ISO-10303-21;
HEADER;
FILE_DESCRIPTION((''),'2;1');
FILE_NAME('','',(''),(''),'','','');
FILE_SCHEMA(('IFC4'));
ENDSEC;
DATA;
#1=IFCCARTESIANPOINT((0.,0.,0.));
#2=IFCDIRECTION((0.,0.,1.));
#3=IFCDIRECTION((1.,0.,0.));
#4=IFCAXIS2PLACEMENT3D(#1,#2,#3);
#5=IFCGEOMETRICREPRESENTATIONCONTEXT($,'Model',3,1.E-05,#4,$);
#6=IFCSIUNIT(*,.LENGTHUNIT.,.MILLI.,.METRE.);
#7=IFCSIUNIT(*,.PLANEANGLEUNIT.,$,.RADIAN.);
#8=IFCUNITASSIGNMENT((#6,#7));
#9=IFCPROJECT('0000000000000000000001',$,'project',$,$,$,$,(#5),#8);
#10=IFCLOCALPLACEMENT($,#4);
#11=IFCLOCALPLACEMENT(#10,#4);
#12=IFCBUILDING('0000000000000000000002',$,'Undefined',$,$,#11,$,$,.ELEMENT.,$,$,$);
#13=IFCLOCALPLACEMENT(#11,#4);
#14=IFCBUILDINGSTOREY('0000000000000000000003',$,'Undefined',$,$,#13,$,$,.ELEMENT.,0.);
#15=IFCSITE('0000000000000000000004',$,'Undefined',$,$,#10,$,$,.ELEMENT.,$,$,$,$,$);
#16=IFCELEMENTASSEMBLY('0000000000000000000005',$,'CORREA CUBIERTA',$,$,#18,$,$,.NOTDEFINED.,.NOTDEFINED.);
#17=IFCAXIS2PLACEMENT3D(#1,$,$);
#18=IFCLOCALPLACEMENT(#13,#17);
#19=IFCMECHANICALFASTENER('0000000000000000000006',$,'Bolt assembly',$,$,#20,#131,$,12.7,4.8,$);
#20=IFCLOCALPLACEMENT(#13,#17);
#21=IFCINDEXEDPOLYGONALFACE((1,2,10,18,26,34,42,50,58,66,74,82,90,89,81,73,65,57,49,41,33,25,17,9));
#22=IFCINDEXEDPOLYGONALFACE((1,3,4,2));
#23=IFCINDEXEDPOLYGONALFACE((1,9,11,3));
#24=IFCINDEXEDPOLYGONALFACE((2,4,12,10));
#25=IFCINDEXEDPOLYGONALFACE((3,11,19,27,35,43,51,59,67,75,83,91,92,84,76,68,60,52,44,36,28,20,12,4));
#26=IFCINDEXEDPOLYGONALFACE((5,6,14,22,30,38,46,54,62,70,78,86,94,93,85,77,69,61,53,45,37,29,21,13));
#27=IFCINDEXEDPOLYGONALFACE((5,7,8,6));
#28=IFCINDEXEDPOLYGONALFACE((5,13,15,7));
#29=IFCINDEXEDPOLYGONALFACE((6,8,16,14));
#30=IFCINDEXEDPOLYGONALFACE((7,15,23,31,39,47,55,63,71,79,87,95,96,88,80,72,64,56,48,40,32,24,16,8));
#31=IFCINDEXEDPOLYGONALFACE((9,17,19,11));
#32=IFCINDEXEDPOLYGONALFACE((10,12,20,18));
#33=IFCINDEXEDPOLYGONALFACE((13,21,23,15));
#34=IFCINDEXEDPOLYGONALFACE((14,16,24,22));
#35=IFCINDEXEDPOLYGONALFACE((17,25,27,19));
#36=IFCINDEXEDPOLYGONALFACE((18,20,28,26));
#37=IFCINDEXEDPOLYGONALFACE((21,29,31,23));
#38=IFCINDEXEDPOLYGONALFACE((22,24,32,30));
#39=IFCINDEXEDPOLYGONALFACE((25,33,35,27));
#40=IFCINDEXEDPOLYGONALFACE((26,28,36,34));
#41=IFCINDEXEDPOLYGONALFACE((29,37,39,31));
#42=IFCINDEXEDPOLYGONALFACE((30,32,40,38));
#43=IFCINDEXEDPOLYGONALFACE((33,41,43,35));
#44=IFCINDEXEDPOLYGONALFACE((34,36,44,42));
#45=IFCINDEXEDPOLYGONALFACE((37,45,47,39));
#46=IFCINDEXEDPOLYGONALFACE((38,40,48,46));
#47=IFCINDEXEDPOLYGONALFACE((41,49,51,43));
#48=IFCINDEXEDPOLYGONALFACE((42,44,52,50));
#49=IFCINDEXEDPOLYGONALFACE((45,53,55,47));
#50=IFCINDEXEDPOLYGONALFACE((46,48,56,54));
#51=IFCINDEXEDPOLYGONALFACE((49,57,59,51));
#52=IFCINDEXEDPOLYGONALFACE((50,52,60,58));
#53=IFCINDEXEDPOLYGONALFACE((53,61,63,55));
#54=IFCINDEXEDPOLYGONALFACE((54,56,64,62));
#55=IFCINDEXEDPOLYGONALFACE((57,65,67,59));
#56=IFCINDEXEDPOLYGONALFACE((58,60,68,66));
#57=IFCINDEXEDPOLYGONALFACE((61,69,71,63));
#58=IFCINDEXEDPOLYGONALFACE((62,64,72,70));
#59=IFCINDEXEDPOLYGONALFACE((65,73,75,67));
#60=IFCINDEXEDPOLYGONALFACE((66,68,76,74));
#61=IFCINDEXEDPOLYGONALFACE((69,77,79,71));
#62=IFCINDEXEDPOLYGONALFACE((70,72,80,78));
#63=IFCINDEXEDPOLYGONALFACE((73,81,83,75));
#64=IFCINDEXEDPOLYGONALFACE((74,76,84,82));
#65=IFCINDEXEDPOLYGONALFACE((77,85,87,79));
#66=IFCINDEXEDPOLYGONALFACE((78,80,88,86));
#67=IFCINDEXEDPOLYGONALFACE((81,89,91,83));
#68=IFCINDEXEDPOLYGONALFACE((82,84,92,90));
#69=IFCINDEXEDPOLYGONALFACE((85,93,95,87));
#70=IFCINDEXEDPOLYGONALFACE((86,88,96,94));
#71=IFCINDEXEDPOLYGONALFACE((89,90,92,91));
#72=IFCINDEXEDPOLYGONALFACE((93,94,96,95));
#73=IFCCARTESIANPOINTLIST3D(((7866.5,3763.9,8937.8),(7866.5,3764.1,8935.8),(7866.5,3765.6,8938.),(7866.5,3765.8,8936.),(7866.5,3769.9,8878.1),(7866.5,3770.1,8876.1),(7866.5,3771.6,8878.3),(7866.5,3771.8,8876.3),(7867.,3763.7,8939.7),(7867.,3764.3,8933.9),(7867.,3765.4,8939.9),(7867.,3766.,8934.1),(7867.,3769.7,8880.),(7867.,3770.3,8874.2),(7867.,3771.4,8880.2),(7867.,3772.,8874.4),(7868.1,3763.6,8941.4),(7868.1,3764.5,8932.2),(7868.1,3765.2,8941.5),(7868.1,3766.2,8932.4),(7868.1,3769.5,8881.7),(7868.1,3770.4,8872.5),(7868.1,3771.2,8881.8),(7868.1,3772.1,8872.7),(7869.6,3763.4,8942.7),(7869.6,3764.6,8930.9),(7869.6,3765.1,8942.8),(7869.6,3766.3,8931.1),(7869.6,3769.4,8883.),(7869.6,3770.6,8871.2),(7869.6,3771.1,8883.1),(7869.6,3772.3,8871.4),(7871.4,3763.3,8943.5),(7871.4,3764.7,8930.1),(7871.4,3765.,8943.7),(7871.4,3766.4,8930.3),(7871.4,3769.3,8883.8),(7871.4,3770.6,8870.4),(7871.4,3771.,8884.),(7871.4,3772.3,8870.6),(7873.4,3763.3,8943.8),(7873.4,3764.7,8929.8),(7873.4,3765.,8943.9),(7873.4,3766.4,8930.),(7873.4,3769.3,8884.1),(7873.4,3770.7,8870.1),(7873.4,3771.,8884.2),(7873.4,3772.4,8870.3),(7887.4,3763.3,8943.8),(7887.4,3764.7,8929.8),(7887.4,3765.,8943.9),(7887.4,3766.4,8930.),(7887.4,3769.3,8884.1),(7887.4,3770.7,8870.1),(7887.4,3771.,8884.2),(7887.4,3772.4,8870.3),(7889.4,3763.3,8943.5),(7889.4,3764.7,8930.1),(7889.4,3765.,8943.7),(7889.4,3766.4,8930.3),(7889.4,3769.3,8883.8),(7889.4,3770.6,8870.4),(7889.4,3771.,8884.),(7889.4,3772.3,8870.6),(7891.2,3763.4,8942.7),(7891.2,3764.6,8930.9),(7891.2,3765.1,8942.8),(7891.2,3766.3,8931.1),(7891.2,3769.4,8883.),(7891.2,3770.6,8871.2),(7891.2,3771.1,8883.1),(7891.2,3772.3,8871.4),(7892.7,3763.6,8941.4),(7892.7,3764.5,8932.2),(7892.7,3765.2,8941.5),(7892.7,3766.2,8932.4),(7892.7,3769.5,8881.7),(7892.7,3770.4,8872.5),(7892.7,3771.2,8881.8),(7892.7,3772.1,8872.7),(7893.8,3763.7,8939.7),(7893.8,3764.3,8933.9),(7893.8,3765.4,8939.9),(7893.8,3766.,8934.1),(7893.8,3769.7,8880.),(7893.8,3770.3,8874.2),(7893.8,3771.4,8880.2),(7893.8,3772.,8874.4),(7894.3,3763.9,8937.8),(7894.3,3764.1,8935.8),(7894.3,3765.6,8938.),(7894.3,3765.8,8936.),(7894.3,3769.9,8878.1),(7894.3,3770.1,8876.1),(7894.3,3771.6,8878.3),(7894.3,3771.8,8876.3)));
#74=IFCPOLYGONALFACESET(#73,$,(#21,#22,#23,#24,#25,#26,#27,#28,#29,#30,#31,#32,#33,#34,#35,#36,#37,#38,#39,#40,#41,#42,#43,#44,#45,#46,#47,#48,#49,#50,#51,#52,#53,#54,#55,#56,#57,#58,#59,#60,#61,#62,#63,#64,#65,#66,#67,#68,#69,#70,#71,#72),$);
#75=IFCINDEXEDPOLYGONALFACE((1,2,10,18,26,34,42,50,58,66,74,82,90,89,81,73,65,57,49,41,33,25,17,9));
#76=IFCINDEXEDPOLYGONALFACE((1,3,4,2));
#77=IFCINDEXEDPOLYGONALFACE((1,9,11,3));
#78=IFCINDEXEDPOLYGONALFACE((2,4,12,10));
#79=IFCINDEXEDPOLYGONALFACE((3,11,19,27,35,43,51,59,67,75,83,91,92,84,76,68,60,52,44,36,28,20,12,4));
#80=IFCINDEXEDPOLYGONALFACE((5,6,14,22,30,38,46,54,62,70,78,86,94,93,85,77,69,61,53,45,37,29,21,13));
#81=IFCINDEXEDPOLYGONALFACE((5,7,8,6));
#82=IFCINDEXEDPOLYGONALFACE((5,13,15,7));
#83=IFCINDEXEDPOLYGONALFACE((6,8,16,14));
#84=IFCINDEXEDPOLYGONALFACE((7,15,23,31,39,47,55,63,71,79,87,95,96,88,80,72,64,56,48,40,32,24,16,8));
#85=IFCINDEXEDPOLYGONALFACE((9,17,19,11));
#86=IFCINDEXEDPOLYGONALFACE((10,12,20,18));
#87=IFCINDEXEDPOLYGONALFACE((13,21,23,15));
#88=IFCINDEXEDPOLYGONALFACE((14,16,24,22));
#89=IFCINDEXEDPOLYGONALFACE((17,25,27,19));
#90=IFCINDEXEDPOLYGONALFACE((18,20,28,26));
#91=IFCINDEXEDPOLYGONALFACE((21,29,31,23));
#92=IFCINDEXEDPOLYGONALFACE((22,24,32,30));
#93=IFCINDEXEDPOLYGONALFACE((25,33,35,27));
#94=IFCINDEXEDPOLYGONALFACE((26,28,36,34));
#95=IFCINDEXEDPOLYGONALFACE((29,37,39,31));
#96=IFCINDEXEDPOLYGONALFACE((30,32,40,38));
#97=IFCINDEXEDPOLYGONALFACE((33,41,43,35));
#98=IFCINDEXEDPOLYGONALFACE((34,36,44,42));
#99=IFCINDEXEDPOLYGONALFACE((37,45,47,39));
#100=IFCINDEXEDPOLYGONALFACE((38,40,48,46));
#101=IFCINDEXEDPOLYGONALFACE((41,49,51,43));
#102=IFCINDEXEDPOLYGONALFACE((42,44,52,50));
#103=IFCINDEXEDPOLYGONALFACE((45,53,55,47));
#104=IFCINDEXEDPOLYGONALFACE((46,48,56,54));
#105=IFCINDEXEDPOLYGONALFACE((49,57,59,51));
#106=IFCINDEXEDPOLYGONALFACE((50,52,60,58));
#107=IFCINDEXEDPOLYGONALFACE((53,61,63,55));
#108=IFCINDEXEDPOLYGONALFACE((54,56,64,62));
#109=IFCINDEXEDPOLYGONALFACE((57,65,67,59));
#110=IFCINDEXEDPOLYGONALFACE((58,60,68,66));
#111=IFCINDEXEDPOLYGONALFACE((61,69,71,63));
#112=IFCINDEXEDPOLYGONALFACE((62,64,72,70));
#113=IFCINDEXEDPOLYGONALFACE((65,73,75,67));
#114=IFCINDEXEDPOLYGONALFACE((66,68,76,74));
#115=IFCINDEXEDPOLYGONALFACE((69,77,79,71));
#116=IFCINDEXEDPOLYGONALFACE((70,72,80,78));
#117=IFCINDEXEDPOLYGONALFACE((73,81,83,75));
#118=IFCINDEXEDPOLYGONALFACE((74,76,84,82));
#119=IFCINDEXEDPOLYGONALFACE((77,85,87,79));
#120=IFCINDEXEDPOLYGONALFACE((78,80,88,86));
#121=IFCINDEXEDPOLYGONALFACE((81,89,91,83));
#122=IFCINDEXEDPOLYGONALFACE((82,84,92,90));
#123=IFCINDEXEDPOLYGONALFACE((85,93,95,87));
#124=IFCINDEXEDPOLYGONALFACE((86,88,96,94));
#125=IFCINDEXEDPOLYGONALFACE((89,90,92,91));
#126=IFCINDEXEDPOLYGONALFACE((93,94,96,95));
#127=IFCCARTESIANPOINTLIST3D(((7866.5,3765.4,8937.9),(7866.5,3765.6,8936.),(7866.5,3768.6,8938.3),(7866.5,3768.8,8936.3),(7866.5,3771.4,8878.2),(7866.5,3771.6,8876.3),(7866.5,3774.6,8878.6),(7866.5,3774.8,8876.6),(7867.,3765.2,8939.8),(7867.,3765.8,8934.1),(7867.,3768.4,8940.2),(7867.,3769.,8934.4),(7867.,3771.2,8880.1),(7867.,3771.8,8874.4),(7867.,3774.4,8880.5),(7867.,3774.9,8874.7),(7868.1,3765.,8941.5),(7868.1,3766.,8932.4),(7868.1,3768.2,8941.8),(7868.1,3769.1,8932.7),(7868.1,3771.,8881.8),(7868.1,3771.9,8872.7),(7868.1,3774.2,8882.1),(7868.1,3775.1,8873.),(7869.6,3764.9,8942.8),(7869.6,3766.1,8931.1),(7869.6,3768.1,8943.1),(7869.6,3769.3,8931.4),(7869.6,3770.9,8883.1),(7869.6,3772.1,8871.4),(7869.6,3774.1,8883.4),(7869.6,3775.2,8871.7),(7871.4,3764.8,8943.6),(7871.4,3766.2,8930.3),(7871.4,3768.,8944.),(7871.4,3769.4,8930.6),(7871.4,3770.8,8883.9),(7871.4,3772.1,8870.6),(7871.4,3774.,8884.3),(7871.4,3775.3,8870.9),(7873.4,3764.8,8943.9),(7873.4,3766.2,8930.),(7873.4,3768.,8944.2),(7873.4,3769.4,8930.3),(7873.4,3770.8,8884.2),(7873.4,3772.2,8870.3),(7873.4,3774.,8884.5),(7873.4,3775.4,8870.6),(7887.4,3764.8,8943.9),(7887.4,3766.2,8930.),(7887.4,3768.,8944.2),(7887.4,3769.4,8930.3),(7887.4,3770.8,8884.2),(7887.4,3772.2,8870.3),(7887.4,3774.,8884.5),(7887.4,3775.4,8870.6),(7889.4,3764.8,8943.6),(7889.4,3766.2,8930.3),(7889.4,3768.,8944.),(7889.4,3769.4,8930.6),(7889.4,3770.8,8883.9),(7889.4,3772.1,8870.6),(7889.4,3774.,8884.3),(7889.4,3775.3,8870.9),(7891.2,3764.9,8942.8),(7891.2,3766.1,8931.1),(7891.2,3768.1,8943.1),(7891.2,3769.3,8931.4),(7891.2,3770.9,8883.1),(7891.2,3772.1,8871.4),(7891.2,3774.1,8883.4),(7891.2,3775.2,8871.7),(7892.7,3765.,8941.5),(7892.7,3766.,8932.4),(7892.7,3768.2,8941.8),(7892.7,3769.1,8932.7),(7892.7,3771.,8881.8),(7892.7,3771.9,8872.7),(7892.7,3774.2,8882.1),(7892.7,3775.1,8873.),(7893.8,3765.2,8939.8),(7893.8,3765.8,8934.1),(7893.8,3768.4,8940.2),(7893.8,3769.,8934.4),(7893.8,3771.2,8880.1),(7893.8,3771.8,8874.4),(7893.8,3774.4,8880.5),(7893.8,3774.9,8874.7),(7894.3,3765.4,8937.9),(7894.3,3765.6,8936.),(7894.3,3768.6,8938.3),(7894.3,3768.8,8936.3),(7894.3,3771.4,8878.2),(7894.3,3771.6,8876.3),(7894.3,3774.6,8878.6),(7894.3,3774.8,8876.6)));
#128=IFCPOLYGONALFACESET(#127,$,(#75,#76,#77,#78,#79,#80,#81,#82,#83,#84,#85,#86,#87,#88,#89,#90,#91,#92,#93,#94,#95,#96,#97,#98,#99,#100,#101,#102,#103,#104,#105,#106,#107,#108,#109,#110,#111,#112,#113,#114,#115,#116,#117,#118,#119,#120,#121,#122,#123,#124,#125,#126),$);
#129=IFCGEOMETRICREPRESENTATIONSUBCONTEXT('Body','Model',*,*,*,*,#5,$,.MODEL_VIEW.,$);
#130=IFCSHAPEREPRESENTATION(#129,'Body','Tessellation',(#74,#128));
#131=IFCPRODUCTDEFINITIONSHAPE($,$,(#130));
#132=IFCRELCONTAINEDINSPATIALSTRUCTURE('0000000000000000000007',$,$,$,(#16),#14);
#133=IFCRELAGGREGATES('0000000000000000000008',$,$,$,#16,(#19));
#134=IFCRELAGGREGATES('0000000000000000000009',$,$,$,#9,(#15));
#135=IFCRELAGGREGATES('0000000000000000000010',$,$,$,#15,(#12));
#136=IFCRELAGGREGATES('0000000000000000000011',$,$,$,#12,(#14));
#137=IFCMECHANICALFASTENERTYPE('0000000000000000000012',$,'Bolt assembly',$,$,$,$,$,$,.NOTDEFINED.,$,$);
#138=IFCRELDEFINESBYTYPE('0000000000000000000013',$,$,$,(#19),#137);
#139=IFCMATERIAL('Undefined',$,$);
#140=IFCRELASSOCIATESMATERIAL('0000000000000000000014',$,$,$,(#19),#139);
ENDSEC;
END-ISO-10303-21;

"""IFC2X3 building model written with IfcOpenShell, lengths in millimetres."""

from ifc_helpers import new_model, entity, si_unit, frame, origin_with_axes, place, context, subcontext, project, spatial, source, transform, mapped, material, type_object, element, aggregate, save


model = new_model("IFC2X3")

# Units and contexts
model_context = context("Model", 3, precision=1e-05, world=origin_with_axes())
body_context = subcontext(model_context, "Body", "Model", "MODEL_VIEW")
ifc_project = project(units=[si_unit("LENGTHUNIT", "METRE", prefix="MILLI"), si_unit("PLANEANGLEUNIT", "RADIAN")], contexts=[model_context])

# Site, building, storey
site_placement = place(None, origin_with_axes())
site = spatial("IfcSite", under=ifc_project, at=site_placement, Name="Undefined", CompositionType="ELEMENT")
building_placement = place(site_placement, origin_with_axes())
building = spatial("IfcBuilding", under=site, at=building_placement, Name="Undefined", CompositionType="ELEMENT")
storey_placement = place(building_placement, origin_with_axes())
storey = spatial("IfcBuildingStorey", under=building, at=storey_placement, Name="Undefined", CompositionType="ELEMENT", Elevation=0.0)

# Shared definitions
ifc_material_1 = material(Name="Undefined")
mechanical_fastener_type = type_object("IfcMechanicalFastenerType", Name="Bolt assembly")

# Element assembly, mechanical fastener
assembly_1_placement = place(storey_placement, origin_with_axes())
assembly_1 = element("IfcElementAssembly", 1, at=assembly_1_placement, inside=storey, Name="CORREA CUBIERTA", AssemblyPlace="NOTDEFINED", PredefinedType="NOTDEFINED")
shared_circle_1 = entity("IfcCircle", entity("IfcAxis2Placement2D", entity("IfcCartesianPoint", [0.0, -7.0]), entity("IfcDirection", [1.0, 0.0])), 7.0)
shared_circle_2 = entity("IfcCircle", entity("IfcAxis2Placement2D", entity("IfcCartesianPoint", [0.0, 7.0]), entity("IfcDirection", [-1.0, 0.0])), 7.0)
shared_composite_curve = entity("IfcCompositeCurve", [entity("IfcCompositeCurveSegment", "CONTINUOUS", True, entity("IfcPolyline", [entity("IfcCartesianPoint", [7.0, 7.0]), entity("IfcCartesianPoint", [7.0, -7.0])])), entity("IfcCompositeCurveSegment", "CONTINUOUS", True, entity("IfcTrimmedCurve", shared_circle_1, [entity("IfcParameterValue", 0.0)], [entity("IfcParameterValue", 3.141593)], False, "PARAMETER")), entity("IfcCompositeCurveSegment", "CONTINUOUS", True, entity("IfcPolyline", [entity("IfcCartesianPoint", [-7.0, -7.0]), entity("IfcCartesianPoint", [-7.0, 7.0])])), entity("IfcCompositeCurveSegment", "DISCONTINUOUS", True, entity("IfcTrimmedCurve", shared_circle_2, [entity("IfcParameterValue", 0.0)], [entity("IfcParameterValue", 3.141593)], False, "PARAMETER"))], False)
shared_shape_1 = source(origin_with_axes(), body_context, "Body", "SweptSolid", [
    entity("IfcExtrudedAreaSolid", entity("IfcArbitraryClosedProfileDef", "AREA", None, shared_composite_curve), entity("IfcAxis2Placement3D", entity("IfcCartesianPoint", [0.0, 3.1, 0.0]), entity("IfcDirection", [0.0, 1.0, 0.0]), entity("IfcDirection", [1.0, 0.0, 0.0])), entity("IfcDirection", [0.0, 0.0, 1.0]), 1.7),
    entity("IfcExtrudedAreaSolid", entity("IfcArbitraryClosedProfileDef", "AREA", None, shared_composite_curve), entity("IfcAxis2Placement3D", entity("IfcCartesianPoint", [0.0, 0.1, 0.0]), entity("IfcDirection", [0.0, 1.0, 0.0]), entity("IfcDirection", [1.0, 0.0, 0.0])), entity("IfcDirection", [0.0, 0.0, 1.0]), 3.2),
])
mechanical_fastener_1_placement = place(assembly_1_placement, frame((7880.4, 3768.8, 8937.3), z_axis=(-1.0, 0.0, 0.0), x_axis=(0.0, 0.099503, -0.995037)))
mechanical_fastener_1 = element("IfcMechanicalFastener", 2, at=mechanical_fastener_1_placement, type_object=mechanical_fastener_type, material=ifc_material_1, Name="Bolt assembly", NominalDiameter=12.7, NominalLength=4.8, context=body_context, shape_type="MappedRepresentation", body=[
    mapped(shared_shape_1, transform((0.0, 0.0, 0.0))),
    mapped(shared_shape_1, transform((60.0, 0.0, 0.0))),
])

aggregate(assembly_1, [mechanical_fastener_1])

save(model, "model.ifc")
